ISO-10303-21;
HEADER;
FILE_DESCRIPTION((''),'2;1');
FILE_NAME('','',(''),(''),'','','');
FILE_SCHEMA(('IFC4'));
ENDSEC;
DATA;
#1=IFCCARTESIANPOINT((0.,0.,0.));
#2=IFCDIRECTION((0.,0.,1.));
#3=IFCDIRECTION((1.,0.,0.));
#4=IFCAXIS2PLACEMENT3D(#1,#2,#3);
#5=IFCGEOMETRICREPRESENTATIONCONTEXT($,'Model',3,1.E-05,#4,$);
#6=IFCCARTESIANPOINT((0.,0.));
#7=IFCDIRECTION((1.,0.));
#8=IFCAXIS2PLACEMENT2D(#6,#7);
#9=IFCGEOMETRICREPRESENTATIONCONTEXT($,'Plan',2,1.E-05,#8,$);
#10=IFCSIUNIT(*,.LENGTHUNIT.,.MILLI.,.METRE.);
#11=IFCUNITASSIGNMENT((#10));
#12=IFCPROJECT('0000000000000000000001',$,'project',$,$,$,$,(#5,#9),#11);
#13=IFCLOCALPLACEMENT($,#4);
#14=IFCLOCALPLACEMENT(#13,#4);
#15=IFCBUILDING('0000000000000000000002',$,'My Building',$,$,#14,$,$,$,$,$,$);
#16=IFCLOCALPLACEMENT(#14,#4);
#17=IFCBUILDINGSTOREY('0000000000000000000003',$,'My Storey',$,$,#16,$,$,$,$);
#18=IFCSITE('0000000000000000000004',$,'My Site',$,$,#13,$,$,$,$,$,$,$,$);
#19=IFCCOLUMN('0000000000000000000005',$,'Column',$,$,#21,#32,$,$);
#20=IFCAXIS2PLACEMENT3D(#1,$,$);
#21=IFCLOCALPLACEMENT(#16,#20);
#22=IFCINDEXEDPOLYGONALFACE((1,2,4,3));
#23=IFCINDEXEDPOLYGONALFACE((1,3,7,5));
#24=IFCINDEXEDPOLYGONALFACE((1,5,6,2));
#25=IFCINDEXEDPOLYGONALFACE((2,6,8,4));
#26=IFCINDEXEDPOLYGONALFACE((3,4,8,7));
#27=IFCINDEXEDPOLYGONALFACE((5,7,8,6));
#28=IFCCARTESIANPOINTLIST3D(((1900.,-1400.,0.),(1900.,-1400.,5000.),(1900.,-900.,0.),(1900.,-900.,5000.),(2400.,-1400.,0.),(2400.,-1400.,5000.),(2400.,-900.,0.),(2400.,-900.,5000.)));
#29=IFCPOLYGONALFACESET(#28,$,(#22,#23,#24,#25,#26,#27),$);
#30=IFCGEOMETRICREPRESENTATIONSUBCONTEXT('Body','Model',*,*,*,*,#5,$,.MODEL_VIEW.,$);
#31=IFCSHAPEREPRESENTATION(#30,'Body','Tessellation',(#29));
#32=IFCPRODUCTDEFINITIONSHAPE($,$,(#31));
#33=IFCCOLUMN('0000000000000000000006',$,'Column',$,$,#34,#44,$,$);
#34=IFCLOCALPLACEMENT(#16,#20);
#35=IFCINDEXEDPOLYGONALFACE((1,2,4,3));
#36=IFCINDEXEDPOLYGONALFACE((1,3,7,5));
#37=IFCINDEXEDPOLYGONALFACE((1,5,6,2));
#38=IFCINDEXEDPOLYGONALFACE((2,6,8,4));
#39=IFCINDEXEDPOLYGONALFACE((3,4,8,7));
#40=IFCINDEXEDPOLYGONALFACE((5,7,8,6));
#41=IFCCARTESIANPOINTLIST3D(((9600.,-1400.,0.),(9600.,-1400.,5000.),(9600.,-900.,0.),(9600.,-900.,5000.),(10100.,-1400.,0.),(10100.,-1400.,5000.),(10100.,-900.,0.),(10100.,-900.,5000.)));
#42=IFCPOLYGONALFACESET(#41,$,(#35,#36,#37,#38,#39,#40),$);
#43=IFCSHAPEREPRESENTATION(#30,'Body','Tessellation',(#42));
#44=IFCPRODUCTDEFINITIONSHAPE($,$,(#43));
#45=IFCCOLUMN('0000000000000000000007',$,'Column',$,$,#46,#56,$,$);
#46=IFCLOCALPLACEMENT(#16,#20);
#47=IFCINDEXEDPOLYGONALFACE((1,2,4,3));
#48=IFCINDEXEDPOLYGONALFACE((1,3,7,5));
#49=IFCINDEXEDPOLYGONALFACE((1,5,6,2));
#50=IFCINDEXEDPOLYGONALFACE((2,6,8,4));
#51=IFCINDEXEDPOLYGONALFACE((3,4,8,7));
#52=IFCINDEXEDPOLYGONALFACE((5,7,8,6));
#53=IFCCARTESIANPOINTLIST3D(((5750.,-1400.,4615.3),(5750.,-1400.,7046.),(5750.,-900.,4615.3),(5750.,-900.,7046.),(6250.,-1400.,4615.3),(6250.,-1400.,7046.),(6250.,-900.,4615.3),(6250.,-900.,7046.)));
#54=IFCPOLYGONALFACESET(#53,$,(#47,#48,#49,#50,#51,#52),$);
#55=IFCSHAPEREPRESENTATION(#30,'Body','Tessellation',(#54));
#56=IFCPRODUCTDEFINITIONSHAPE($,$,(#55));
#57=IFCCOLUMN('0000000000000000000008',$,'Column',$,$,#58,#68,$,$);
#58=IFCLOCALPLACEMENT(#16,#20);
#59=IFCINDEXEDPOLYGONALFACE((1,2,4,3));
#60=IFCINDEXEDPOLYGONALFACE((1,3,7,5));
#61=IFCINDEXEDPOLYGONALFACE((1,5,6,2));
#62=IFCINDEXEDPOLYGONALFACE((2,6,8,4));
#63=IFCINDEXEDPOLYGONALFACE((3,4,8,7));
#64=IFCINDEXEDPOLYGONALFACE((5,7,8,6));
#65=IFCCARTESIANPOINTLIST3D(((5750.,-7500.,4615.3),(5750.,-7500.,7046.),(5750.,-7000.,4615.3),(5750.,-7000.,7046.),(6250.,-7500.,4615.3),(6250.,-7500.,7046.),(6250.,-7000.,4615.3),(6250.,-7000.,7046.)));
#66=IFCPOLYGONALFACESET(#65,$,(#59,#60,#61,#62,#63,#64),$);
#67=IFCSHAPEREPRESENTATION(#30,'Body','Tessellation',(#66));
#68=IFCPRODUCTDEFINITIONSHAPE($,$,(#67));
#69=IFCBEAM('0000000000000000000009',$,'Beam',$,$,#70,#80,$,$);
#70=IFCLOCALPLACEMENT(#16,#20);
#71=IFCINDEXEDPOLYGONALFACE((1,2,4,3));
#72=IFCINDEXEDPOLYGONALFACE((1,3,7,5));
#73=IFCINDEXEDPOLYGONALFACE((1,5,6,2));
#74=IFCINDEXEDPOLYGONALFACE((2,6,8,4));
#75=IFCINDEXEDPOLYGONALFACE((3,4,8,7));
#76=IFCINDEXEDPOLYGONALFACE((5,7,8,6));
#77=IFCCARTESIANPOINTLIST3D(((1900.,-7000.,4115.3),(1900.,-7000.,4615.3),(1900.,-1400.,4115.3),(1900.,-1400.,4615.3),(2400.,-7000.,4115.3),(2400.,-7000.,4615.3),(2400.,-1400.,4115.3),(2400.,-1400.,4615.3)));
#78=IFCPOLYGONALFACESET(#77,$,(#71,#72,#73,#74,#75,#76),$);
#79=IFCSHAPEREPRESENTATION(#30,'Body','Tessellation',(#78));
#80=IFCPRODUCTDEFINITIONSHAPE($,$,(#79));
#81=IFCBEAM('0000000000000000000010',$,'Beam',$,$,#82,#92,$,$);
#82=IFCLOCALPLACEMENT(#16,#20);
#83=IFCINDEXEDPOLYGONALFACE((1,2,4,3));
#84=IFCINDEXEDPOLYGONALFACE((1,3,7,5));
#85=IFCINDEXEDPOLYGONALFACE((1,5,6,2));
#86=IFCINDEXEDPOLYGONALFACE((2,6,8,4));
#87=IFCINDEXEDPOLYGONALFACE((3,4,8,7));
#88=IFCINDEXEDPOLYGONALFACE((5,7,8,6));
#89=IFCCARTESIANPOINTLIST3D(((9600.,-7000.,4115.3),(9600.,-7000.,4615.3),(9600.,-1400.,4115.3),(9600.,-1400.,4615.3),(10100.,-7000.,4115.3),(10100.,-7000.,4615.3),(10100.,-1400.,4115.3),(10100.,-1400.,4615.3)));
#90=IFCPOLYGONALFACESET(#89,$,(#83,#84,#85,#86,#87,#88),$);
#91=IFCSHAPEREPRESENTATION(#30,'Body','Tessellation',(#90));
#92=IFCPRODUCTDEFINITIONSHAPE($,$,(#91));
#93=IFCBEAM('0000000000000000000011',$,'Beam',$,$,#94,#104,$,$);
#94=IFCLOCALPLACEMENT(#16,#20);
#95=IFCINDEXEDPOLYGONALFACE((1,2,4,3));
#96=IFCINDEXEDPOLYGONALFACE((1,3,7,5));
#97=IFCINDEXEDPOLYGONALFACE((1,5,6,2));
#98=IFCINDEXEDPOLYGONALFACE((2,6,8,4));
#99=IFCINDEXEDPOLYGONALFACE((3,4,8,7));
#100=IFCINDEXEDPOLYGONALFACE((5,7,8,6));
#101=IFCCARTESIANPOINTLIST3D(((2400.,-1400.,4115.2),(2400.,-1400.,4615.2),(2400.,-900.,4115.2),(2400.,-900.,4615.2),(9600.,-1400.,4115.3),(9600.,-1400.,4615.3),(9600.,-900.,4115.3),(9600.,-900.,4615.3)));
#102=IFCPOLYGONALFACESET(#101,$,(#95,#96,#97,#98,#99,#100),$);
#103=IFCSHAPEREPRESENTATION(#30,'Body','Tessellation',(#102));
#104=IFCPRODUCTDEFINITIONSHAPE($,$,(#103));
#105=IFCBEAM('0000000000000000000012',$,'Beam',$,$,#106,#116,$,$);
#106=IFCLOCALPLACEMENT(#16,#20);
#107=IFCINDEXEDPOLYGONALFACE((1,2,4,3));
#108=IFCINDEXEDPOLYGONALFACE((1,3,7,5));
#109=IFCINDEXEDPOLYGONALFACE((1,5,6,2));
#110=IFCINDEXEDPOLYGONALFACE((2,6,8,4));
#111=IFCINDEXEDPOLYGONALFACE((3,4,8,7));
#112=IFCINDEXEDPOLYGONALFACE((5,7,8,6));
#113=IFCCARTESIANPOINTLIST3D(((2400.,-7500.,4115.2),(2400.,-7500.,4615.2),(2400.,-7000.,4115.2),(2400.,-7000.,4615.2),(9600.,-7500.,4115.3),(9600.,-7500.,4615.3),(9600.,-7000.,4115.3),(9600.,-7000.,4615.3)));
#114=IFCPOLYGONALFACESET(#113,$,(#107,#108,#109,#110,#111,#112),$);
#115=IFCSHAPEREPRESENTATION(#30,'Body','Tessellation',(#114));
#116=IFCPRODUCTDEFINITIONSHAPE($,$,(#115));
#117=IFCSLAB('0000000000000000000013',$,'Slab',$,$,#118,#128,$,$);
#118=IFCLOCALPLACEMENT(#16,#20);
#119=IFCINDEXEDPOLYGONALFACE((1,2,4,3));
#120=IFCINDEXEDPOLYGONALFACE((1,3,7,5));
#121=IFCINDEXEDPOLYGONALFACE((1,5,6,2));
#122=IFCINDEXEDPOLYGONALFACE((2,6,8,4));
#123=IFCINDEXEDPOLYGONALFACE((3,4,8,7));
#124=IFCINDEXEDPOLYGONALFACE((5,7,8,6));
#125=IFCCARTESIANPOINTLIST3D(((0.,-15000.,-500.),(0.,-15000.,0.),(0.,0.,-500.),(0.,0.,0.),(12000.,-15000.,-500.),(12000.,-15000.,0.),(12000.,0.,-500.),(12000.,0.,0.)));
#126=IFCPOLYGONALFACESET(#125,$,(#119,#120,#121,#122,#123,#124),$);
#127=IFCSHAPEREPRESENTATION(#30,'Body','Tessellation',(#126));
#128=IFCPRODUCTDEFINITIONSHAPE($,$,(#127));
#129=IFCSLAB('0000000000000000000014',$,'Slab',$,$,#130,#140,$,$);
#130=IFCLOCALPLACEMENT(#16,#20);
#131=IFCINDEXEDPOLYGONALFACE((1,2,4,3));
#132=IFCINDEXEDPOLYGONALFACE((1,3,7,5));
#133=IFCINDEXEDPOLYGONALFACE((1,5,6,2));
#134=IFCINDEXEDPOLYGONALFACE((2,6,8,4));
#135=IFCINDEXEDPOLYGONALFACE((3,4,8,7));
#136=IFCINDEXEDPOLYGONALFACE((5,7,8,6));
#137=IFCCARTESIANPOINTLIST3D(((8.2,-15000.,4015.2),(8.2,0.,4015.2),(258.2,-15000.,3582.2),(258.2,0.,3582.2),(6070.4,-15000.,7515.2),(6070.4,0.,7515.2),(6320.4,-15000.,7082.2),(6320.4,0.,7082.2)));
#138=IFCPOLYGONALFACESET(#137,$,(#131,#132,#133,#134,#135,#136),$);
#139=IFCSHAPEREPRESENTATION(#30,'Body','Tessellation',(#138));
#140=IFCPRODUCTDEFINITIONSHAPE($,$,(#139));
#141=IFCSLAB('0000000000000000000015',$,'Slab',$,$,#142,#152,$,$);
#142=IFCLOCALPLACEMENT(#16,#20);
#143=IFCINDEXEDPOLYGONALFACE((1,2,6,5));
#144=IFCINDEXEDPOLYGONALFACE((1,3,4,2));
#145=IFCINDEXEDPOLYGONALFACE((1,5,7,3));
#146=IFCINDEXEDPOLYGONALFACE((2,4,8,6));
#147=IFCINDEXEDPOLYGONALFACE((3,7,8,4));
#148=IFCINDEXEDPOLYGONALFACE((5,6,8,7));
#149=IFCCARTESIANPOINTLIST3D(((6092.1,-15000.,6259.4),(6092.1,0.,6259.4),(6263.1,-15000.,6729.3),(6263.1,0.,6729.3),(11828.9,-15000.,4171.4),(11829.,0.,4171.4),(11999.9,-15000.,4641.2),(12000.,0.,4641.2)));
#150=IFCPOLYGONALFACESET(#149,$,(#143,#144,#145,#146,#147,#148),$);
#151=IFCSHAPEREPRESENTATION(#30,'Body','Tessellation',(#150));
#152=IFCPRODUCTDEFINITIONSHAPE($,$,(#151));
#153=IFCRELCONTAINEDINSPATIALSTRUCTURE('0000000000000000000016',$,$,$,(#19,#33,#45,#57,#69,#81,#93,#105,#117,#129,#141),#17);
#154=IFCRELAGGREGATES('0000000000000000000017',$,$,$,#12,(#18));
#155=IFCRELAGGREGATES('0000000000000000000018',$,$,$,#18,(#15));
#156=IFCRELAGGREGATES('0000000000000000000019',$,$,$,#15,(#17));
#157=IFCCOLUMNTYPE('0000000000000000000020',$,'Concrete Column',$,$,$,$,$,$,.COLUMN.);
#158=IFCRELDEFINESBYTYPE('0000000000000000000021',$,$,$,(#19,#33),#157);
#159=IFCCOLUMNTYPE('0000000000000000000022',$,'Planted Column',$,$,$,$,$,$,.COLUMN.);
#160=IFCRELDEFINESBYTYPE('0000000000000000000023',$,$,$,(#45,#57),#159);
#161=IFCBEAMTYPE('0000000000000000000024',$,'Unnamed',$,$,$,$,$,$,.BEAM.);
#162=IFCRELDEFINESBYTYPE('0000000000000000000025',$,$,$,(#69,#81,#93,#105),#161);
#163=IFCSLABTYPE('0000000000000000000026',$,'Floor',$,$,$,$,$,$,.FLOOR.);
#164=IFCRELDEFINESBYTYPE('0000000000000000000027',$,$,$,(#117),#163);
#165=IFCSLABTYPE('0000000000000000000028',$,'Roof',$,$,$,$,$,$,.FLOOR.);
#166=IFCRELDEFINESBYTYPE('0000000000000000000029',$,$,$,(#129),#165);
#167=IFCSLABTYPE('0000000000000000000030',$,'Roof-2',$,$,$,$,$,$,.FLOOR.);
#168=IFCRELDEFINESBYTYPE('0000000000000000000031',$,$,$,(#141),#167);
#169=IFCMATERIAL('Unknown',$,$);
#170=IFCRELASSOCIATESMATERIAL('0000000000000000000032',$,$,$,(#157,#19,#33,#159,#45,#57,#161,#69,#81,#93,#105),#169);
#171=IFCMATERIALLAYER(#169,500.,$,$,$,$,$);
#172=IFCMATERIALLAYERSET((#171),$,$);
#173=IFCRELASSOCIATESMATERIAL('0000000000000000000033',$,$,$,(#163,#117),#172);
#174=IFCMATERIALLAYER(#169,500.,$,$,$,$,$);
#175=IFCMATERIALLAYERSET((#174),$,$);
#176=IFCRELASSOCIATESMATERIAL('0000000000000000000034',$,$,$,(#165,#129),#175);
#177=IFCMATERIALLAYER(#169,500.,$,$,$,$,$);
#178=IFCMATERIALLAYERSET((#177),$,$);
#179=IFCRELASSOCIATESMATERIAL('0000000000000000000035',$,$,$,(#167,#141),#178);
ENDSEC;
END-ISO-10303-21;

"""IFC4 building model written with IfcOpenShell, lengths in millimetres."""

from ifc_helpers import new_model, si_unit, frame, origin_with_axes, origin_2d_with_axis, place, context, subcontext, project, spatial, indexed_curve, rectangle, outline, extrude, material, layer, layer_set, layer_usage, material_profile, profile_set, profile_usage, type_object, element, save


model = new_model("IFC4")

# Units and contexts
model_context = context("Model", 3, precision=1e-05, world=origin_with_axes())
plan_context = context("Plan", 2, precision=1e-05, world=origin_2d_with_axis())
body_context_1 = subcontext(model_context, "Body", "Model", "MODEL_VIEW")
ifc_project = project(units=[si_unit("LENGTHUNIT", "METRE", prefix="MILLI")], contexts=[model_context, plan_context])

# Site, building, storey
site_placement = place(None, origin_with_axes())
site = spatial("IfcSite", under=ifc_project, at=site_placement, Name="My Site")
building_placement = place(site_placement, origin_with_axes())
building = spatial("IfcBuilding", under=site, at=building_placement, Name="My Building")
storey_placement = place(building_placement, origin_with_axes())
storey = spatial("IfcBuildingStorey", under=building, at=storey_placement, Name="My Storey")

# Columns
ifc_material = material(Name="Unknown")
ifc_material_profile_1 = material_profile(ifc_material, rectangle(XDim=500.0, YDim=500.0))
ifc_profile_set_1 = profile_set([ifc_material_profile_1])
ifc_profile_usage_1 = profile_usage(ifc_profile_set_1, cardinal=1)
column_type_1 = type_object("IfcColumnType", Name="Concrete Column", PredefinedType="COLUMN", material=ifc_profile_set_1)
column_1_placement = place(storey_placement, frame((2400.0, -1400.0, 0.0), z_axis=(0.0, 0.0, 1.0), x_axis=(1.0, 0.0, 0.0)))
element("IfcColumn", 1, at=column_1_placement, inside=storey, type_object=column_type_1, material=ifc_profile_usage_1, Name="Column", context=body_context_1, shape_type="SweptSolid", body=[
    extrude(rectangle(XDim=500.0, YDim=500.0), frame((-250.0, 250.0, 0.0), z_axis=(0.0, 0.0, 1.0), x_axis=(1.0, 0.0, 0.0)), (0.0, 0.0, 1.0), 5000.0),
])
ifc_profile_usage_2 = profile_usage(ifc_profile_set_1, cardinal=1)
column_2_placement = place(storey_placement, frame((10100.0, -1400.0, 0.0), z_axis=(0.0, 0.0, 1.0), x_axis=(1.0, 0.0, 0.0)))
element("IfcColumn", 2, at=column_2_placement, inside=storey, type_object=column_type_1, material=ifc_profile_usage_2, Name="Column", context=body_context_1, shape_type="SweptSolid", body=[
    extrude(rectangle(XDim=500.0, YDim=500.0), frame((-250.0, 250.0, 0.0), z_axis=(0.0, 0.0, 1.0), x_axis=(1.0, 0.0, 0.0)), (0.0, 0.0, 1.0), 5000.0),
])
ifc_material_profile_2 = material_profile(ifc_material, rectangle(XDim=500.0, YDim=500.0))
ifc_profile_set_2 = profile_set([ifc_material_profile_2])
ifc_profile_usage_3 = profile_usage(ifc_profile_set_2, cardinal=5)
column_type_2 = type_object("IfcColumnType", Name="Planted Column", PredefinedType="COLUMN", material=ifc_profile_set_2)
column_3_placement = place(storey_placement, frame((6000.0, -1150.0, 4615.3), z_axis=(0.0, 0.0, 1.0), x_axis=(1.0, 0.0, 0.0)))
element("IfcColumn", 3, at=column_3_placement, inside=storey, type_object=column_type_2, material=ifc_profile_usage_3, Name="Column", context=body_context_1, shape_type="SweptSolid", body=[
    extrude(rectangle(XDim=500.0, YDim=500.0), origin_with_axes(), (0.0, 0.0, 1.0), 2430.7),
])
ifc_profile_usage_4 = profile_usage(ifc_profile_set_2, cardinal=5)
column_4_placement = place(storey_placement, frame((6000.0, -7250.0, 4615.3), z_axis=(0.0, 0.0, 1.0), x_axis=(1.0, 0.0, 0.0)))
element("IfcColumn", 4, at=column_4_placement, inside=storey, type_object=column_type_2, material=ifc_profile_usage_4, Name="Column", context=body_context_1, shape_type="SweptSolid", body=[
    extrude(rectangle(XDim=500.0, YDim=500.0), origin_with_axes(), (0.0, 0.0, 1.0), 2430.7),
])

# Beams
ifc_material_profile_3 = material_profile(ifc_material, rectangle(XDim=500.0, YDim=500.0))
ifc_profile_set_3 = profile_set([ifc_material_profile_3])
ifc_profile_usage_5 = profile_usage(ifc_profile_set_3, cardinal=5)
beam_type = type_object("IfcBeamType", Name="Unnamed", PredefinedType="BEAM", material=ifc_profile_set_3)
beam_1_placement = place(storey_placement, frame((2150.0, -1400.0, 4365.3), z_axis=(0.0, -1.0, 0.0), x_axis=(1.0, 0.0, 0.0)))
element("IfcBeam", 5, at=beam_1_placement, inside=storey, type_object=beam_type, material=ifc_profile_usage_5, Name="Beam", context=body_context_1, shape_type="SweptSolid", body=[
    extrude(rectangle(XDim=500.0, YDim=500.0), origin_with_axes(), (0.0, 0.0, 1.0), 5600.0),
])
ifc_profile_usage_6 = profile_usage(ifc_profile_set_3, cardinal=5)
beam_2_placement = place(storey_placement, frame((9850.0, -1400.0, 4365.3), z_axis=(0.0, -1.0, 0.0), x_axis=(1.0, 0.0, 0.0)))
element("IfcBeam", 6, at=beam_2_placement, inside=storey, type_object=beam_type, material=ifc_profile_usage_6, Name="Beam", context=body_context_1, shape_type="SweptSolid", body=[
    extrude(rectangle(XDim=500.0, YDim=500.0), origin_with_axes(), (0.0, 0.0, 1.0), 5600.0),
])
ifc_profile_usage_7 = profile_usage(ifc_profile_set_3, cardinal=5)
beam_3_placement = place(storey_placement, frame((2400.0, -1150.0, 4365.2), z_axis=(1.0, -0.000001, 0.000001), x_axis=(0.000001, 1.0, 0.0)))
element("IfcBeam", 7, at=beam_3_placement, inside=storey, type_object=beam_type, material=ifc_profile_usage_7, Name="Beam", context=body_context_1, shape_type="SweptSolid", body=[
    extrude(rectangle(XDim=500.0, YDim=500.0), origin_with_axes(), (0.0, 0.0, 1.0), 7200.0),
])
ifc_profile_usage_8 = profile_usage(ifc_profile_set_3, cardinal=5)
beam_4_placement = place(storey_placement, frame((2400.0, -7250.0, 4365.2), z_axis=(1.0, -0.000001, 0.000001), x_axis=(0.000001, 1.0, 0.0)))
element("IfcBeam", 8, at=beam_4_placement, inside=storey, type_object=beam_type, material=ifc_profile_usage_8, Name="Beam", context=body_context_1, shape_type="SweptSolid", body=[
    extrude(rectangle(XDim=500.0, YDim=500.0), origin_with_axes(), (0.0, 0.0, 1.0), 7200.0),
])

# Slabs
ifc_layer_1 = layer(ifc_material, 500.0)
ifc_layer_set_1 = layer_set([ifc_layer_1])
ifc_layer_usage_1 = layer_usage(ifc_layer_set_1, "AXIS3", "POSITIVE", -500.0)
slab_type_1 = type_object("IfcSlabType", Name="Floor", PredefinedType="FLOOR", material=ifc_layer_set_1)
slab_1_placement = place(storey_placement, origin_with_axes())
element("IfcSlab", 9, at=slab_1_placement, inside=storey, type_object=slab_type_1, material=ifc_layer_usage_1, Name="Slab", context=body_context_1, shape_type="SweptSolid", body=[
    extrude(outline(indexed_curve([(0.0, 0.0), (12000.0, 0.0), (12000.0, -15000.0), (0.0, -15000.0), (0.0, 0.0)])), frame((0.0, 0.0, -500.0), z_axis=(0.0, 0.0, 1.0), x_axis=(1.0, 0.0, 0.0)), (0.0, 0.0, 1.0), 500.0),
])
ifc_layer_2 = layer(ifc_material, 500.0)
ifc_layer_set_2 = layer_set([ifc_layer_2])
ifc_layer_usage_2 = layer_usage(ifc_layer_set_2, "AXIS3", "POSITIVE", -500.0)
slab_type_2 = type_object("IfcSlabType", Name="Roof", PredefinedType="FLOOR", material=ifc_layer_set_2)
slab_2_placement = place(storey_placement, frame((8.2, 0.0, 4015.2), z_axis=(-0.5, 0.0, 0.866025), x_axis=(0.866025, 0.0, 0.5)))
element("IfcSlab", 10, at=slab_2_placement, inside=storey, type_object=slab_type_2, material=ifc_layer_usage_2, Name="Slab", context=body_context_1, shape_type="SweptSolid", body=[
    extrude(outline(indexed_curve([(0.0, 0.0), (7000.0, 0.0), (7000.0, -15000.0), (0.0, -15000.0), (0.0, 0.0)])), frame((0.0, 0.0, -500.0), z_axis=(0.0, 0.0, 1.0), x_axis=(1.0, 0.0, 0.0)), (0.0, 0.0, 1.0), 500.0),
])
ifc_layer_3 = layer(ifc_material, 500.0)
ifc_layer_set_3 = layer_set([ifc_layer_3])
ifc_layer_usage_3 = layer_usage(ifc_layer_set_3, "AXIS3", "POSITIVE", -500.0)
slab_type_3 = type_object("IfcSlabType", Name="Roof-2", PredefinedType="FLOOR", material=ifc_layer_set_3)
slab_3_placement = place(storey_placement, frame((12000.0, 0.0, 4641.2), z_axis=(0.34202, 0.0, 0.939693), x_axis=(0.939693, 0.0, -0.34202)))
element("IfcSlab", 11, at=slab_3_placement, inside=storey, type_object=slab_type_3, material=ifc_layer_usage_3, Name="Slab", context=body_context_1, shape_type="SweptSolid", body=[
    extrude(outline(indexed_curve([(0.0, 0.0), (-6105.1, 0.0), (-6105.1, -15000.0), (-0.1, -15000.0), (0.0, 0.0)])), frame((0.0, 0.0, -500.0), z_axis=(0.0, 0.0, 1.0), x_axis=(1.0, 0.0, 0.0)), (0.0, 0.0, 1.0), 500.0),
])

save(model, "model.ifc")
